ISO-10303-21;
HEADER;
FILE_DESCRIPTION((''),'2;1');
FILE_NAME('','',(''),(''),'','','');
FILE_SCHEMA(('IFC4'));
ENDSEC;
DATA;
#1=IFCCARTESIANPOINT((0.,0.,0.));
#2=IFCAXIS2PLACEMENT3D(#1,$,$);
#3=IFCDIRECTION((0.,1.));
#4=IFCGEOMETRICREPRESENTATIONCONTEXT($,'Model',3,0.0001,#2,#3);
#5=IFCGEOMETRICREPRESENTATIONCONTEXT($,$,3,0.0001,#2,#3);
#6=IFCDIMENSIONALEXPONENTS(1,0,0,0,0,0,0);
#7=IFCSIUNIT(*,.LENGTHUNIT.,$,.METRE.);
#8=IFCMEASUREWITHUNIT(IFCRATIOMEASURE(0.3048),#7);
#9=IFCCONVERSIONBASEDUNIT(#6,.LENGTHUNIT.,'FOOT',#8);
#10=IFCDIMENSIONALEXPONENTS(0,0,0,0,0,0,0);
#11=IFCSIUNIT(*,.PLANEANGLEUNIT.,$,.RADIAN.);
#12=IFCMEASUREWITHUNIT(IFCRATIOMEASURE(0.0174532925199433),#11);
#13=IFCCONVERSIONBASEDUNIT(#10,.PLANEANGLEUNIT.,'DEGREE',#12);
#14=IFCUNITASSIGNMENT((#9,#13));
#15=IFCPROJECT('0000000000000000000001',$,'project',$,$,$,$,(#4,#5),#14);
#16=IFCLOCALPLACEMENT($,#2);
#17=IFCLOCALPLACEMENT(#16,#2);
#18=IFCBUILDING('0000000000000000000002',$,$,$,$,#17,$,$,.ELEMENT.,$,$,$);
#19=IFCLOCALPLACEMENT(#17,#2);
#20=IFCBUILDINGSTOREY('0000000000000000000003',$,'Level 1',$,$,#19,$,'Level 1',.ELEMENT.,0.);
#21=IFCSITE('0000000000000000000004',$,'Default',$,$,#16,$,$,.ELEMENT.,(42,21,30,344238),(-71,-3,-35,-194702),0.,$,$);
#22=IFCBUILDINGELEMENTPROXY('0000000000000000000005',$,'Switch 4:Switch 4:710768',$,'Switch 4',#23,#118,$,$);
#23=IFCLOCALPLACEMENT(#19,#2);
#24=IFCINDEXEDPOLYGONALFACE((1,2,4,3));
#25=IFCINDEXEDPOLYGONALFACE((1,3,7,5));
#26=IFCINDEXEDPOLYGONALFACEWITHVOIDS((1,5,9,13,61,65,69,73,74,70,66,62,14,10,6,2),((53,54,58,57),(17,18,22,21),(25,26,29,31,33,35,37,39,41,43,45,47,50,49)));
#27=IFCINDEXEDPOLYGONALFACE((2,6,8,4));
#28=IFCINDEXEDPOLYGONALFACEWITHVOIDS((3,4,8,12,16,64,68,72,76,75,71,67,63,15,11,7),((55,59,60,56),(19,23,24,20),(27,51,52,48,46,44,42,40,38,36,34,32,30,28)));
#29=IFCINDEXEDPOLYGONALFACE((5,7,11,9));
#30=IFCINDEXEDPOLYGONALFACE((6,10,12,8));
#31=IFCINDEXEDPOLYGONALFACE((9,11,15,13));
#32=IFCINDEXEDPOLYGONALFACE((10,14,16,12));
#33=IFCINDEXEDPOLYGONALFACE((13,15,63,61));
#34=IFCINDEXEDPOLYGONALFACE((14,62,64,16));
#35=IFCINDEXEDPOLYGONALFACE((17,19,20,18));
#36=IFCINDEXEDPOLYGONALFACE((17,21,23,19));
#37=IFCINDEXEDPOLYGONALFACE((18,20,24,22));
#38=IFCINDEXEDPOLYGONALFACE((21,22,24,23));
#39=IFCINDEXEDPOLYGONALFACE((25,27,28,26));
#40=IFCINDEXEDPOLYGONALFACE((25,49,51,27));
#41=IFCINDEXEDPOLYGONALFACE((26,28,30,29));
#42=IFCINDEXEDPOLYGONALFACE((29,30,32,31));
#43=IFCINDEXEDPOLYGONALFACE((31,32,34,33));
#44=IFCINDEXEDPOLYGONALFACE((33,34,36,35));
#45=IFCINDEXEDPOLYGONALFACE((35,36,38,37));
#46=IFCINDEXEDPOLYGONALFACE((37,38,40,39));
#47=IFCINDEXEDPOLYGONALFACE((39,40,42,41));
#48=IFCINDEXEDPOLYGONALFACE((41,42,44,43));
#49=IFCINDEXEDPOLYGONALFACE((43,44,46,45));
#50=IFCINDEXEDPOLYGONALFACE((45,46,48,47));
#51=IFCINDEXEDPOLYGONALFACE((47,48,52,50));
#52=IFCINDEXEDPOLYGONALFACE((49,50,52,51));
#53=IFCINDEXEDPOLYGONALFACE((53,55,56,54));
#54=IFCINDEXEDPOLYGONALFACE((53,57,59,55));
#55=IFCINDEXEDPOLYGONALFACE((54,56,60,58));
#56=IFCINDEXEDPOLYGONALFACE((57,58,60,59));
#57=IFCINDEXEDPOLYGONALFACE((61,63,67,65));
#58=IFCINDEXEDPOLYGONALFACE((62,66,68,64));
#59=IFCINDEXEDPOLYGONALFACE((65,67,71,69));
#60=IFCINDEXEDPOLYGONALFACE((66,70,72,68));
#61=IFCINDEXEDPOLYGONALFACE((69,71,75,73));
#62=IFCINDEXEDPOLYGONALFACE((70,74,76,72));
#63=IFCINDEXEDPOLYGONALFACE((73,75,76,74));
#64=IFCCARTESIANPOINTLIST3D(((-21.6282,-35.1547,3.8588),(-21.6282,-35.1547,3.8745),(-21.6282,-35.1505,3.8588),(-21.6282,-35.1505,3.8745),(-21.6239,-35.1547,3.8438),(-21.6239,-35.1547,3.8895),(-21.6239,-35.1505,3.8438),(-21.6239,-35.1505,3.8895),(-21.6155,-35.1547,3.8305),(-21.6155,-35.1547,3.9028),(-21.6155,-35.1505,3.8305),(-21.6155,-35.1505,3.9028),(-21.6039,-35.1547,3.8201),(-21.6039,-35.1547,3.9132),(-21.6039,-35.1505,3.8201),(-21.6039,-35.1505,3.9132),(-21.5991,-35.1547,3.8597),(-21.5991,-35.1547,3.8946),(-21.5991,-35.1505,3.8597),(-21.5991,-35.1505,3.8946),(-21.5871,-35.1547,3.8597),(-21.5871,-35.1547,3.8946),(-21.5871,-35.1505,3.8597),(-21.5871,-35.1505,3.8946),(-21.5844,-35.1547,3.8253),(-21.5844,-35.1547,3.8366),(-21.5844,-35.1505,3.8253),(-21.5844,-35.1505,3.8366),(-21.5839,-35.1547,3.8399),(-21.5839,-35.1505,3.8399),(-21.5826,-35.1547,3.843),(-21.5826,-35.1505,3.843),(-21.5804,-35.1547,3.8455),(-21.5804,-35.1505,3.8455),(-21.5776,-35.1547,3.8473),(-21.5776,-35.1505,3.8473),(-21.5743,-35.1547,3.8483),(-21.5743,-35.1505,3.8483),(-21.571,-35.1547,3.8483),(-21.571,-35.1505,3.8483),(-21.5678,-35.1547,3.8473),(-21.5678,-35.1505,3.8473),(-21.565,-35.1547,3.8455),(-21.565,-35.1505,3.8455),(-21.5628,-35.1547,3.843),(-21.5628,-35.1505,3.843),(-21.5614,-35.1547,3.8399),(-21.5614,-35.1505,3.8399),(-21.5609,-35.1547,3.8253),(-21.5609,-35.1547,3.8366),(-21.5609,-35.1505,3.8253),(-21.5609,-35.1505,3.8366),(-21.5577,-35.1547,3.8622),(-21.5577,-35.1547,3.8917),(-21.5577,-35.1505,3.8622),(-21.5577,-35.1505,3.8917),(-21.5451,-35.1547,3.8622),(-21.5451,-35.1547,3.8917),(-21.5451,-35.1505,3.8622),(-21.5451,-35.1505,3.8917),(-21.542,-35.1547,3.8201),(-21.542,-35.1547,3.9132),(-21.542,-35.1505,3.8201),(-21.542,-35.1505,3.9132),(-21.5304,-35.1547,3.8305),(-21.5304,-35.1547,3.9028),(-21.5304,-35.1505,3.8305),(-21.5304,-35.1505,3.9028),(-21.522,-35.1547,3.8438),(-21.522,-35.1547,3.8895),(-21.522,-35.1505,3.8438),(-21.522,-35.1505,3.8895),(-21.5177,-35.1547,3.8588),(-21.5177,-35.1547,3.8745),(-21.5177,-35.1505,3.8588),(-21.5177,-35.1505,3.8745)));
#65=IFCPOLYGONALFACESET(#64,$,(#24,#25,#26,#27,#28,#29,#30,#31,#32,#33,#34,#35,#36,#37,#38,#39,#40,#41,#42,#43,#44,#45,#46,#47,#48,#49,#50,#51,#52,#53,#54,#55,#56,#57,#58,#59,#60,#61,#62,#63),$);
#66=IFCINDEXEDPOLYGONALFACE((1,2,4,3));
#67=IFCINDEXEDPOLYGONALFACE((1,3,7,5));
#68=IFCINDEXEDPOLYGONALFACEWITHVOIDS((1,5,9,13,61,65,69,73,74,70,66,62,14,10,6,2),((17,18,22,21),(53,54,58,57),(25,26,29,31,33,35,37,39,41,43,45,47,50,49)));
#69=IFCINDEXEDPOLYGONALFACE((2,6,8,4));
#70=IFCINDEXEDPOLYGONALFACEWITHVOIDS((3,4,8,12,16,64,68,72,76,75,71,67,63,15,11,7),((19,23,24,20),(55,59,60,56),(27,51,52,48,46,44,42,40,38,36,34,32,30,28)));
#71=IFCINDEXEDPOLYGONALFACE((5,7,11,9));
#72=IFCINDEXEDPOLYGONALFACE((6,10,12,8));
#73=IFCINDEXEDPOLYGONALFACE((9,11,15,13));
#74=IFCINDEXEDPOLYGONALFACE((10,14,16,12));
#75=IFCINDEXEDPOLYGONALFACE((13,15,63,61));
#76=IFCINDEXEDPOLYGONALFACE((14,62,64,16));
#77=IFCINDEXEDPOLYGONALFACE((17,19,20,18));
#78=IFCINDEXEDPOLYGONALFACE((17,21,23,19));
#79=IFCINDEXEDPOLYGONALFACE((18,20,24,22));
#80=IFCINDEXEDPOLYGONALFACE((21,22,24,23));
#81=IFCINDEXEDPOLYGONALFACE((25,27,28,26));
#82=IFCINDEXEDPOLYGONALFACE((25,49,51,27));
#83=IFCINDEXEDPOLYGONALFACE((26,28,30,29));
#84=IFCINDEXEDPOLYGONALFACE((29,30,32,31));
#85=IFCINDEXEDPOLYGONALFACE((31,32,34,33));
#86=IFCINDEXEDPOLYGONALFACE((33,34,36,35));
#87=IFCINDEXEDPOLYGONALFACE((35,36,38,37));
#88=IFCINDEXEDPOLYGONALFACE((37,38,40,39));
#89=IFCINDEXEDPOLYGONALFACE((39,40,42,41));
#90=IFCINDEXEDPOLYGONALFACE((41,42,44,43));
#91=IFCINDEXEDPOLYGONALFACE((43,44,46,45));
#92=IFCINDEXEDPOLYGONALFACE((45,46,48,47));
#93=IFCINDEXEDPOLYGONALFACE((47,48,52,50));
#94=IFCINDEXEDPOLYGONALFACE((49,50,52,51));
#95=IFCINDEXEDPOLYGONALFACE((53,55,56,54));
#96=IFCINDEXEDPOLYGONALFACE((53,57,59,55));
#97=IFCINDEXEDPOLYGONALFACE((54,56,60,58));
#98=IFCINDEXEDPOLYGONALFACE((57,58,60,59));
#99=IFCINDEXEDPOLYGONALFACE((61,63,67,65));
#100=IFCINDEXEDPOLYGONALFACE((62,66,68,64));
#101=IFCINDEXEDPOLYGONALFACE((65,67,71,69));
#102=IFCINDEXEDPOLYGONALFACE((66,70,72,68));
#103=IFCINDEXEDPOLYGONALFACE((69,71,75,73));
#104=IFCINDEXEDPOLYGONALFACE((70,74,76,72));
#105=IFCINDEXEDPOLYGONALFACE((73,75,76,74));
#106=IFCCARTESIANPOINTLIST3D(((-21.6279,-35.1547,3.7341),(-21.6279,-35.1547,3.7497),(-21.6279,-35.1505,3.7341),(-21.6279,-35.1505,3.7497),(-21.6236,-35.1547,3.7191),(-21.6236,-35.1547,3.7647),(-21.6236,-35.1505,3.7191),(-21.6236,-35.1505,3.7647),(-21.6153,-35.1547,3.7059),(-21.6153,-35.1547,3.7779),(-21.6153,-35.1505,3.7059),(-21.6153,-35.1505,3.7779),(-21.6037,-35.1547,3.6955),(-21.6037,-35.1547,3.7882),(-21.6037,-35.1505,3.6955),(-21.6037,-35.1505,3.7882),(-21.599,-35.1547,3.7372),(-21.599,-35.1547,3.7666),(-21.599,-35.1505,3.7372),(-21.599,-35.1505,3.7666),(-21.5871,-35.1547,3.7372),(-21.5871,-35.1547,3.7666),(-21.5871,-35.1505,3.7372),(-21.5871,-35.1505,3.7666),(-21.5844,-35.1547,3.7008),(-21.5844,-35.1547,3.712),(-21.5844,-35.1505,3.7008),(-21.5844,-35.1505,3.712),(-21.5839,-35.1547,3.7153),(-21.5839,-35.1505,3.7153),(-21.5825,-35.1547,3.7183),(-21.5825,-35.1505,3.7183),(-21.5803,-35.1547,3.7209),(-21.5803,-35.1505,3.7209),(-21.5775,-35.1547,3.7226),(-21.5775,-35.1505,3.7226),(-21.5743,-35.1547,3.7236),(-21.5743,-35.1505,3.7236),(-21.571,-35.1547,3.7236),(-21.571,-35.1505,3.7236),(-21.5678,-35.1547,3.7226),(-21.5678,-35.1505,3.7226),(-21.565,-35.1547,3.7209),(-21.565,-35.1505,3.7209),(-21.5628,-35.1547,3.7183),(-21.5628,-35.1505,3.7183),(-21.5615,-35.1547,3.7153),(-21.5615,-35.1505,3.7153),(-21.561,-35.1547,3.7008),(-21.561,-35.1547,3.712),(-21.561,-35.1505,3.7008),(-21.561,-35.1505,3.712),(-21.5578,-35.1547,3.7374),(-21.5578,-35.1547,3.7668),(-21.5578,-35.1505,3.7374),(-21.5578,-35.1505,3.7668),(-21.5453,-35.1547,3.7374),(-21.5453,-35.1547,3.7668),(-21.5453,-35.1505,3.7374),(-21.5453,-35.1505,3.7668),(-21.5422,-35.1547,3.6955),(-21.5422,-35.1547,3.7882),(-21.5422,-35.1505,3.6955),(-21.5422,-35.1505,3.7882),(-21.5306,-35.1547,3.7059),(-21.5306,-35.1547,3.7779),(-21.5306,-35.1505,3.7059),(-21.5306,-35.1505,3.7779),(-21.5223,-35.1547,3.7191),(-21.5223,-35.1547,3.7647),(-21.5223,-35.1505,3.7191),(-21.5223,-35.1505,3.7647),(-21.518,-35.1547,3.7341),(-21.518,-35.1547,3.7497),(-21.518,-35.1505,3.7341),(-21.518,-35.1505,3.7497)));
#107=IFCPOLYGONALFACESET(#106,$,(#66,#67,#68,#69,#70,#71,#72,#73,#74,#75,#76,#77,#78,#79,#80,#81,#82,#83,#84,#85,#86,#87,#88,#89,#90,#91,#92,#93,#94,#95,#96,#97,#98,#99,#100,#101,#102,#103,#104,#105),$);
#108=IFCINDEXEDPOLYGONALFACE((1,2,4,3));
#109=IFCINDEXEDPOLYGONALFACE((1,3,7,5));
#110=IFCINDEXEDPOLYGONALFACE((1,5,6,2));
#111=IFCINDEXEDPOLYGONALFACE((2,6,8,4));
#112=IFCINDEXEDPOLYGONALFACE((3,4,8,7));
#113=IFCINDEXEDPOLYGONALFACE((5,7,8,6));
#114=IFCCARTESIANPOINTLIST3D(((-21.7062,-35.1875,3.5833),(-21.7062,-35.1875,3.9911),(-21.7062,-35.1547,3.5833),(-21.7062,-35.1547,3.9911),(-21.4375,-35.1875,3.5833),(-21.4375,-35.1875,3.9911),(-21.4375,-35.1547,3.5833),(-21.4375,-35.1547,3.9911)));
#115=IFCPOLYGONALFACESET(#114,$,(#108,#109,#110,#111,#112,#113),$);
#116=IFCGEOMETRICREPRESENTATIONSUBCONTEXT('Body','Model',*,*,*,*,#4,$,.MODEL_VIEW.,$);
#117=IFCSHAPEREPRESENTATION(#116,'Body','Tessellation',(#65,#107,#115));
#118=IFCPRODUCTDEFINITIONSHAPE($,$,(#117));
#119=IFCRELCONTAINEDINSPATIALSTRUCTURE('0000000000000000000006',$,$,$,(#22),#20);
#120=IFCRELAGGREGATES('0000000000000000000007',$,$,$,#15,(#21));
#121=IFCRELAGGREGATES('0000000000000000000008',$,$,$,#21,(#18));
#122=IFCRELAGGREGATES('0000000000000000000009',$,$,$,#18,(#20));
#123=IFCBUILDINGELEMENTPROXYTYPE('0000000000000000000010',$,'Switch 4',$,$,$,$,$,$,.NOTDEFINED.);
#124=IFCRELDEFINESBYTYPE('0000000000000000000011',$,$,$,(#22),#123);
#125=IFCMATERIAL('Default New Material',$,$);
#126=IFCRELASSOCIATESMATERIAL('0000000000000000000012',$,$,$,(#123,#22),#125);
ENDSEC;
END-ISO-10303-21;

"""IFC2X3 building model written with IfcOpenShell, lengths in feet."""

from ifc_helpers import new_model, entity, si_unit, converted_unit, direction, frame, frame_2d, origin, origin_2d_with_axis, place, context, subcontext, project, spatial, polyline, circle_curve, parameter, trimmed, segment, composite_curve, rectangle, outline, extrude, source, transform, mapped, material, type_object, type_shapes, element, save


model = new_model("IFC2X3")

# Units and contexts
model_context = context("Model", 3, precision=0.0001, world=origin(), true_north=direction((0.0, 1.0)))
context_of_model = context(None, 3, precision=0.0001, world=origin(), true_north=direction((0.0, 1.0)))
body_context = subcontext(model_context, "Body", "Model", "MODEL_VIEW")
ifc_project = project(units=[converted_unit("LENGTHUNIT", "FOOT", entity("IfcRatioMeasure", 0.3048), si_unit("LENGTHUNIT", "METRE"), dimensions=[1, 0, 0, 0, 0, 0, 0]), converted_unit("PLANEANGLEUNIT", "DEGREE", entity("IfcRatioMeasure", 0.0174532925199433), si_unit("PLANEANGLEUNIT", "RADIAN"), dimensions=[0, 0, 0, 0, 0, 0, 0])], contexts=[model_context, context_of_model])

# Site, building, storey
site_placement = place(None, origin())
site = spatial("IfcSite", under=ifc_project, at=site_placement, Name="Default", CompositionType="ELEMENT", RefLatitude=(42, 21, 30, 344238), RefLongitude=(-71, -3, -35, -194702), RefElevation=0.0)
building_placement = place(site_placement, origin())
building = spatial("IfcBuilding", under=site, at=building_placement, CompositionType="ELEMENT")
storey_placement = place(building_placement, origin())
storey = spatial("IfcBuildingStorey", under=building, at=storey_placement, Name="Level 1", LongName="Level 1", CompositionType="ELEMENT", Elevation=0.0)

# Shared definitions
ifc_material = material(Name="Default New Material")

# Building element proxy
building_element_proxy_type_1 = type_object("IfcBuildingElementProxyType", Name="Switch 4", PredefinedType="NOTDEFINED", material=ifc_material)
shared_shape_1 = source(origin(), body_context, "Body", "SweptSolid", [
    extrude(outline(composite_curve([segment(polyline([(-0.0309, -0.0466), (0.0309, -0.0466)]), True, "CONTINUOUS"), segment(trimmed(circle_curve(frame_2d((-0.0003, 0.0), x_axis=(-1.0, 0.0)), 0.0561), [parameter(123.794741)], [parameter(236.205259)], True, "PARAMETER"), True, "CONTINUOUS"), segment(polyline([(0.0309, 0.0466), (-0.0309, 0.0466)]), True, "CONTINUOUS"), segment(trimmed(circle_curve(frame_2d((0.0003, 0.0), x_axis=(1.0, 0.0)), 0.0561), [parameter(123.794741)], [parameter(236.205259)], True, "PARAMETER"), True, "CONTINUOUS")], self_intersect=False), holes=[polyline([(0.0142, 0.0279), (0.0262, 0.0279), (0.0262, -0.0069), (0.0142, -0.0069), (0.0142, 0.0279)]), polyline([(-0.0153, 0.025), (-0.0153, -0.0045), (-0.0278, -0.0045), (-0.0278, 0.025), (-0.0153, 0.025)]), composite_curve([segment(polyline([(-0.012, -0.0413), (-0.012, -0.03)]), True, "CONTINUOUS"), segment(trimmed(circle_curve(frame_2d((-0.0003, -0.03), x_axis=(-1.0, 0.0)), 0.0117), [parameter(180.0)], [parameter(0.0)], True, "PARAMETER"), False, "CONTINUOUS"), segment(polyline([(0.0115, -0.03), (0.0115, -0.0413)]), True, "CONTINUOUS"), segment(polyline([(0.0115, -0.0413), (-0.012, -0.0413)]), True, "CONTINUOUS")], self_intersect=False)]), frame((-0.0011, 0.0328, 0.2833), z_axis=(0.0, 1.0, 0.0), x_axis=(-1.0, 0.0, 0.0)), (0.0, 0.0, 1.0), 0.0042),
    extrude(outline(composite_curve([segment(polyline([(-0.0308, -0.0464), (0.0308, -0.0464)]), True, "CONTINUOUS"), segment(trimmed(circle_curve(frame_2d((-0.0003, 0.0), x_axis=(-1.0, 0.0)), 0.0558), [parameter(123.794741)], [parameter(236.205259)], True, "PARAMETER"), True, "CONTINUOUS"), segment(polyline([(0.0308, 0.0464), (-0.0308, 0.0464)]), True, "CONTINUOUS"), segment(trimmed(circle_curve(frame_2d((0.0003, 0.0), x_axis=(1.0, 0.0)), 0.0558), [parameter(123.794741)], [parameter(236.205259)], True, "PARAMETER"), True, "CONTINUOUS")], self_intersect=False), holes=[polyline([(0.0141, 0.0247), (0.026, 0.0247), (0.026, -0.0047), (0.0141, -0.0047), (0.0141, 0.0247)]), polyline([(-0.0152, 0.0249), (-0.0152, -0.0045), (-0.0277, -0.0045), (-0.0277, 0.0249), (-0.0152, 0.0249)]), composite_curve([segment(polyline([(-0.012, -0.0411), (-0.012, -0.0299)]), True, "CONTINUOUS"), segment(trimmed(circle_curve(frame_2d((-0.0003, -0.0299), x_axis=(-1.0, 0.0)), 0.0117), [parameter(180.0)], [parameter(0.0)], True, "PARAMETER"), False, "CONTINUOUS"), segment(polyline([(0.0114, -0.0299), (0.0114, -0.0411)]), True, "CONTINUOUS"), segment(polyline([(0.0114, -0.0411), (-0.012, -0.0411)]), True, "CONTINUOUS")], self_intersect=False)]), frame((-0.0011, 0.0328, 0.1586), z_axis=(0.0, 1.0, 0.0), x_axis=(-1.0, 0.0, 0.0)), (0.0, 0.0, 1.0), 0.0042),
    extrude(rectangle(XDim=0.0328, YDim=0.2687, at=origin_2d_with_axis()), frame((0.0, 0.0164, 0.0), z_axis=(0.0, 0.0, 1.0), x_axis=(0.0, -1.0, 0.0)), (0.0, 0.0, 1.0), 0.4078),
])
type_shapes(building_element_proxy_type_1, [shared_shape_1])
for number, where, name in (
    (1, (-21.5718, -35.1875, 3.5833), "Switch 4:Switch 4:710768"),
):
    element("IfcBuildingElementProxy", number, at=place(storey_placement, frame(where)), inside=storey, type_object=building_element_proxy_type_1, material=ifc_material, Name=name, ObjectType="Switch 4", context=body_context, shape_type="MappedRepresentation", body=[
        mapped(shared_shape_1, transform((0.0, 0.0, 0.0), scale=1.0)),
    ])

save(model, "model.ifc")
